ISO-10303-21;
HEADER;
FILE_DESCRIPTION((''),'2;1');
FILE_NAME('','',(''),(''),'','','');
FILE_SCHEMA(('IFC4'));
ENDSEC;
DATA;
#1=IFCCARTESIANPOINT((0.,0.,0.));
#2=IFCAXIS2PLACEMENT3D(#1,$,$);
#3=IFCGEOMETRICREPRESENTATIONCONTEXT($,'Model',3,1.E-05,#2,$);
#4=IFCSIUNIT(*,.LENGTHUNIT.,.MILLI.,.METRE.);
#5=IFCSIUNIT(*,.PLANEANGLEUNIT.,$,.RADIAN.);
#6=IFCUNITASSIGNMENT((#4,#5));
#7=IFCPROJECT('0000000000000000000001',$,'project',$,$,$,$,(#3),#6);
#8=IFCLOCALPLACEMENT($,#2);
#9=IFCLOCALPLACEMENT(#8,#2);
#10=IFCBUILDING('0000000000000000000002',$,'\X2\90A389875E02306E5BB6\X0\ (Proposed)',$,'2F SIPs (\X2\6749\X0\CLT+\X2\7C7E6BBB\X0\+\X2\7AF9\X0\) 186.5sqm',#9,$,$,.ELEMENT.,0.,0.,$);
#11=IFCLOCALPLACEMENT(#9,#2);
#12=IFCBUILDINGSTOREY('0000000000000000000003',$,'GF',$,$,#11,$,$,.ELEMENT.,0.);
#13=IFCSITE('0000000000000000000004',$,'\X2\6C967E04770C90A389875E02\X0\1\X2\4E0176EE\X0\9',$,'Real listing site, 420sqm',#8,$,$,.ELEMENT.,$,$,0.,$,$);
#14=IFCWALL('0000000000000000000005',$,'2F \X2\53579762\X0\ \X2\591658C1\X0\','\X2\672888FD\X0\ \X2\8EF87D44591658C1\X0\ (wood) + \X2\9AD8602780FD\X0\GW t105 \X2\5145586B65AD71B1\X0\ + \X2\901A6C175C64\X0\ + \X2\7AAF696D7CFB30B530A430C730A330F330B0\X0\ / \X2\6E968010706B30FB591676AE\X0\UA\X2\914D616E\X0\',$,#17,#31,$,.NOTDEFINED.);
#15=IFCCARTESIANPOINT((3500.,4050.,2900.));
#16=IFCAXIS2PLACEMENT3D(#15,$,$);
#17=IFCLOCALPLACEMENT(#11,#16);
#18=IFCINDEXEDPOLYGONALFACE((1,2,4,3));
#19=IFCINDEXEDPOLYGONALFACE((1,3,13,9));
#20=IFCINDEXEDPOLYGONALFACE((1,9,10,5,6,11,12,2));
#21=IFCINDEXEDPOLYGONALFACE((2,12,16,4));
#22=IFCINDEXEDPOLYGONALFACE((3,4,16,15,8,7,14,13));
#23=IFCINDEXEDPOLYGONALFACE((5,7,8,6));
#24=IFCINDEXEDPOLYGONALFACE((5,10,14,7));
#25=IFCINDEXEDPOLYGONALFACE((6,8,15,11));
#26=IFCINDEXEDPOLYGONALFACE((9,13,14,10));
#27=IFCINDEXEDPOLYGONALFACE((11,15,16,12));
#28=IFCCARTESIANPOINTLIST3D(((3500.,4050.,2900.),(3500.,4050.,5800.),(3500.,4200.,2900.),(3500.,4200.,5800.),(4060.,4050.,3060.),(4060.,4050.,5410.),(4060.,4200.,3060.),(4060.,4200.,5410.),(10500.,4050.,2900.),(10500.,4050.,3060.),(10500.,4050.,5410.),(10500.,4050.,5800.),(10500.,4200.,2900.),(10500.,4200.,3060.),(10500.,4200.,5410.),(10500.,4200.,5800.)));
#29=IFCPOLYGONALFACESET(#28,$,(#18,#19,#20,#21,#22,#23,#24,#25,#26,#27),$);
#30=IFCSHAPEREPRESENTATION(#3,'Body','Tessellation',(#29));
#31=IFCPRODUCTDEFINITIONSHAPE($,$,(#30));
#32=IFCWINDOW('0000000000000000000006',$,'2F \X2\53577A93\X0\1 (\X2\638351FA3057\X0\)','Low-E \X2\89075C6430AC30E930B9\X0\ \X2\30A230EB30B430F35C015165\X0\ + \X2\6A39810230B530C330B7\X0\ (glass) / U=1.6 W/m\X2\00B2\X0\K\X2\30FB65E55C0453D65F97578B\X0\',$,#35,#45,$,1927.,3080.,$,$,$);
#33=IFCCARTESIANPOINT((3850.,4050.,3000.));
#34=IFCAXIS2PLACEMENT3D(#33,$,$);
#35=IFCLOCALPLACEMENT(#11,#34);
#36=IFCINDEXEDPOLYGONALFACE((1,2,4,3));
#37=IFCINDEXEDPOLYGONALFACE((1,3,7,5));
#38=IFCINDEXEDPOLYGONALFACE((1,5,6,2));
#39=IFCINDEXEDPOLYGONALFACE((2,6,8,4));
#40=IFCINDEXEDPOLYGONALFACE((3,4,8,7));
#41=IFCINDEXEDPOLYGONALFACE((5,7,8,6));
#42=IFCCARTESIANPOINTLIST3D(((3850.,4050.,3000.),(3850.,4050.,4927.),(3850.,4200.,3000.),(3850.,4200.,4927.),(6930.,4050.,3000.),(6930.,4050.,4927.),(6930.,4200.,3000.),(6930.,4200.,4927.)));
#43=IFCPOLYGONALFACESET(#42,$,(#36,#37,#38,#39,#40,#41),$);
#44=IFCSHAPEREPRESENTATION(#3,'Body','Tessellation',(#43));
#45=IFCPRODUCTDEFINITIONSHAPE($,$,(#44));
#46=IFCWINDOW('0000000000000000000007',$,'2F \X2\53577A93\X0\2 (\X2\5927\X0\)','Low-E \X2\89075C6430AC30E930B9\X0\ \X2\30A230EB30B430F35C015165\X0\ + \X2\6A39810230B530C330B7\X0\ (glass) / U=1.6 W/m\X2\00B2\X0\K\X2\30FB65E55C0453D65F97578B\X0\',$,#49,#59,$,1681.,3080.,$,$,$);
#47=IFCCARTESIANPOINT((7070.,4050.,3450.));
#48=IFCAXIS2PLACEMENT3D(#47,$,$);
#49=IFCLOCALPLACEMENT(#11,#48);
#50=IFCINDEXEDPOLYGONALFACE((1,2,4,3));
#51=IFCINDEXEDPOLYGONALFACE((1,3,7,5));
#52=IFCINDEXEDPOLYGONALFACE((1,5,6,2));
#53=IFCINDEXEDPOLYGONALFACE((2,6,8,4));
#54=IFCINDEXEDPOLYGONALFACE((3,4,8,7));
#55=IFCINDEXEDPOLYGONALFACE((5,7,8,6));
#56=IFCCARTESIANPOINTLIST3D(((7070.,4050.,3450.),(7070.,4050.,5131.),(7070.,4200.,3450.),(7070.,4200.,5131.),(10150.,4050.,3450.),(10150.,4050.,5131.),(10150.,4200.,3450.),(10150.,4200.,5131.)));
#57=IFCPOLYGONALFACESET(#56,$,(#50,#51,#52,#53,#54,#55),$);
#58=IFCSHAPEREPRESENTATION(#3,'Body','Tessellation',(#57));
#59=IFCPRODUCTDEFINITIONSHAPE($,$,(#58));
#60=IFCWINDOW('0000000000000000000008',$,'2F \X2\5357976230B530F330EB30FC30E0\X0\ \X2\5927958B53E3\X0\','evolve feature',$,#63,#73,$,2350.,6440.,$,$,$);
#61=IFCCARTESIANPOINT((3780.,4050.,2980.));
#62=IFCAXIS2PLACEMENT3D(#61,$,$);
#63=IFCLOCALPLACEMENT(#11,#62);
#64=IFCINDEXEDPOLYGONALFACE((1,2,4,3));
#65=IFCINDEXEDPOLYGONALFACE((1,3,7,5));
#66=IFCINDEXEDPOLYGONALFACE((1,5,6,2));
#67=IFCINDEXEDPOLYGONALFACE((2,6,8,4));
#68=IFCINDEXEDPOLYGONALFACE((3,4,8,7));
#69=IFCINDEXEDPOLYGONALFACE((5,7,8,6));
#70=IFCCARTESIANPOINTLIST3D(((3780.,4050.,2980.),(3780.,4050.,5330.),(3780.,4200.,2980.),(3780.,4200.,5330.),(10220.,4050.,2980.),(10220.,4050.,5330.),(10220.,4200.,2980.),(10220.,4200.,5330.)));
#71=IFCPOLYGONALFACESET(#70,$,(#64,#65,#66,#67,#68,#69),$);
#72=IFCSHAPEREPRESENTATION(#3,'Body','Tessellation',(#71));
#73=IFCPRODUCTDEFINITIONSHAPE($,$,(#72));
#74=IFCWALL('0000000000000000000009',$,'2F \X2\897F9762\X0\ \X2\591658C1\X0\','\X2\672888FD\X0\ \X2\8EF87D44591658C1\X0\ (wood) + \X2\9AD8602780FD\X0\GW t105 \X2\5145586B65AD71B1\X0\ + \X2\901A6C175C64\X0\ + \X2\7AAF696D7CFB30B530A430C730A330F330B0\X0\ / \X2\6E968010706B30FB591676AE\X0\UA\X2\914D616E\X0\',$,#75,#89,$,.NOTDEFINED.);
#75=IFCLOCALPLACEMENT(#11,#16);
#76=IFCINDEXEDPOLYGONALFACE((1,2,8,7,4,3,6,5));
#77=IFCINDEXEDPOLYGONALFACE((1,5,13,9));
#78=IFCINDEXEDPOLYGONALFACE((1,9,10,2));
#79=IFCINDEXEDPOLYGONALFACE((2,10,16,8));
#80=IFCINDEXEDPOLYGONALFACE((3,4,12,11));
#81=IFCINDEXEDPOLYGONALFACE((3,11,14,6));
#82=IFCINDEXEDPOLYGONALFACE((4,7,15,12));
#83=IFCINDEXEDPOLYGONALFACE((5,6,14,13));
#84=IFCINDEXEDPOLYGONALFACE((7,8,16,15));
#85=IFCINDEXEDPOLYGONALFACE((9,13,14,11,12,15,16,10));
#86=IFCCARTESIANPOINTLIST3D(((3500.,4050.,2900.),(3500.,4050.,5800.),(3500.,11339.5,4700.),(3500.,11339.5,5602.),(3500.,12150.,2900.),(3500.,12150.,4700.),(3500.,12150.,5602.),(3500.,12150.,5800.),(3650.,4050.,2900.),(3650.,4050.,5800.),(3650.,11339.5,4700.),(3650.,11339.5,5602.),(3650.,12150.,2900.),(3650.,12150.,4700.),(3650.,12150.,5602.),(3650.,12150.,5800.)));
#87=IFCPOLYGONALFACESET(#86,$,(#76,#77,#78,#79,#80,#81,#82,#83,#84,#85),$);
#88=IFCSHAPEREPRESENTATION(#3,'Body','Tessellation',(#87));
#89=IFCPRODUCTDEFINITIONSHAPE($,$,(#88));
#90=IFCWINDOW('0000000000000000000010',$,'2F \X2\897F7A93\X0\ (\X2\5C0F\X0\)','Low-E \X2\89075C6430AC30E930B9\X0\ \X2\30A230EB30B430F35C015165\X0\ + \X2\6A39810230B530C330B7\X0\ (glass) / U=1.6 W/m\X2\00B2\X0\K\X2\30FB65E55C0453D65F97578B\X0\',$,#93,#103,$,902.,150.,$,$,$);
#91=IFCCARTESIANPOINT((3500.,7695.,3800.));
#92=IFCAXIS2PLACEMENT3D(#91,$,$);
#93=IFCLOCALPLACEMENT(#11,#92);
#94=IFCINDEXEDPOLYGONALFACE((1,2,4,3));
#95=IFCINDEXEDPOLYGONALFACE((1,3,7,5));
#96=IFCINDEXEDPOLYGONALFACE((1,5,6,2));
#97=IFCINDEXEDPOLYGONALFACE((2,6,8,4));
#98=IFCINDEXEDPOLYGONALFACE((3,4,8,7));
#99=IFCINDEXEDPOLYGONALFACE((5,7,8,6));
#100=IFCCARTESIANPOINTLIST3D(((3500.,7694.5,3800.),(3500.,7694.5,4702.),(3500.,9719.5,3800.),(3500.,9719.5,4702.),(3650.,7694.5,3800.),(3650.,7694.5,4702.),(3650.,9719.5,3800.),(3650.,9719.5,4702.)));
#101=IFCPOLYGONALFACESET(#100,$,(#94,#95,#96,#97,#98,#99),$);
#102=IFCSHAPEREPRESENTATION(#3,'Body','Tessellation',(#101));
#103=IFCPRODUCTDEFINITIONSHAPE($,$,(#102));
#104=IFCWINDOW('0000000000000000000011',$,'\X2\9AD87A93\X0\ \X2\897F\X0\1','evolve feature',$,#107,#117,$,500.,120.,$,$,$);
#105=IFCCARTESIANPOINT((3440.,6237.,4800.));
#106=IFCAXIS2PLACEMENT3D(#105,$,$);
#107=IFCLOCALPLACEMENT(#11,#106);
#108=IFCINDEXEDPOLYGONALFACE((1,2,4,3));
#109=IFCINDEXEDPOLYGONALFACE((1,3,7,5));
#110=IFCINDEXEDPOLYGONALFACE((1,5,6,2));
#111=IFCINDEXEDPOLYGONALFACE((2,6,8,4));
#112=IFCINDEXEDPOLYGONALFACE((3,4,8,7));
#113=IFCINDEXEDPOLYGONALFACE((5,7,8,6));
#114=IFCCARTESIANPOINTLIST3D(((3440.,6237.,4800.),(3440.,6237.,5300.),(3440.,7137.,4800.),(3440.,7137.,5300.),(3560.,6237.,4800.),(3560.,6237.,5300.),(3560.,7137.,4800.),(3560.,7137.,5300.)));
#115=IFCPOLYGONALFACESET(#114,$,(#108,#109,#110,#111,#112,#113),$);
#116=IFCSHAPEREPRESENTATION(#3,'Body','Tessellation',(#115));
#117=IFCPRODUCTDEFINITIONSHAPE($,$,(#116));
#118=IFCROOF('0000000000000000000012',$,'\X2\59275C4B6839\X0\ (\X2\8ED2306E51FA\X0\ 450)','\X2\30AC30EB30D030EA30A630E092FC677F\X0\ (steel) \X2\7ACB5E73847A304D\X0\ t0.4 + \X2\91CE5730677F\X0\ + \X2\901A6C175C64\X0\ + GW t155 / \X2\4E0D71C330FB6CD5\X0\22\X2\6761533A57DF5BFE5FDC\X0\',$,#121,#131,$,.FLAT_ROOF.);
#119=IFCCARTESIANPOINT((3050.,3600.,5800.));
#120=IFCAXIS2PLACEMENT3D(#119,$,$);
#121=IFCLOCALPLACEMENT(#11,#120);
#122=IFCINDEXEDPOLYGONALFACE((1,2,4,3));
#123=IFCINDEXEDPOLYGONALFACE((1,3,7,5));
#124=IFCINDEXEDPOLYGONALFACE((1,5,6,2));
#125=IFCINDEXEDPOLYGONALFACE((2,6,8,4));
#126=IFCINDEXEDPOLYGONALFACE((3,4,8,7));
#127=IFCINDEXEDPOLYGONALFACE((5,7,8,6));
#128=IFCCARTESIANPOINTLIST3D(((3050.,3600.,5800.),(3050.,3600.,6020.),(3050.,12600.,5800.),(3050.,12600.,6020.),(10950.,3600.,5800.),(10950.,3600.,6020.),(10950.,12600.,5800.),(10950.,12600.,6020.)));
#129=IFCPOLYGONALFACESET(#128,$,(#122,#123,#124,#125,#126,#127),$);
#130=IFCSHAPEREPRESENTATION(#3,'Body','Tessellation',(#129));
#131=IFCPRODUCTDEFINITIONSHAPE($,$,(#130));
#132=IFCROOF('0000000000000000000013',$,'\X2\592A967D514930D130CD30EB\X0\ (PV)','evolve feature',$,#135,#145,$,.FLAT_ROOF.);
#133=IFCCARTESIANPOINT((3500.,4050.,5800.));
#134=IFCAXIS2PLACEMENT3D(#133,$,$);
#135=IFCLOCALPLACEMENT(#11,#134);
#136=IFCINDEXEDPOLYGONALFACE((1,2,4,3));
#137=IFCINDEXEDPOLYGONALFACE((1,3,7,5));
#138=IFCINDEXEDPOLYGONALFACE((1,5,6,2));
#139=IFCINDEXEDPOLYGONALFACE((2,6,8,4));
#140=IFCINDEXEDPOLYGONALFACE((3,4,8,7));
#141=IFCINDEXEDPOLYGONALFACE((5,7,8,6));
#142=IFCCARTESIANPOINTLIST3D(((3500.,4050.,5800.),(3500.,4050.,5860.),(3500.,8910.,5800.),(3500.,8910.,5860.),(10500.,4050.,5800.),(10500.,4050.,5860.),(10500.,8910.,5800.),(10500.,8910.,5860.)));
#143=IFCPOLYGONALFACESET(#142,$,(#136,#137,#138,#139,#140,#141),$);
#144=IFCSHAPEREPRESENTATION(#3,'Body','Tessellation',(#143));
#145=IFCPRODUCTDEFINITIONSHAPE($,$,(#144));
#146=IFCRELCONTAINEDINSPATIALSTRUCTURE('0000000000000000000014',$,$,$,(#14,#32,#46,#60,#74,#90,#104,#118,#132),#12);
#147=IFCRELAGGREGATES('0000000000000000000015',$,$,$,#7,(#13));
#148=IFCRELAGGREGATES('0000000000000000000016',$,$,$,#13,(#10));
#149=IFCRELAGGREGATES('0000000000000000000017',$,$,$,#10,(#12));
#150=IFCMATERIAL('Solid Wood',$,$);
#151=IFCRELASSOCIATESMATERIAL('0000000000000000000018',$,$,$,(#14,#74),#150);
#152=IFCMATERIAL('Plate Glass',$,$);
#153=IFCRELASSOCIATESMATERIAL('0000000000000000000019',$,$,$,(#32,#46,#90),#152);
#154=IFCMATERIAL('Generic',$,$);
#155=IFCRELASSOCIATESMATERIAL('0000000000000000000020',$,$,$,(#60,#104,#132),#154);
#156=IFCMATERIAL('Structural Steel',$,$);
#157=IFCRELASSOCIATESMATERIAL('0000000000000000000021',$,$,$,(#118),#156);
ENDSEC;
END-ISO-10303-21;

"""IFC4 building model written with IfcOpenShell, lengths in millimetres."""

from ifc_helpers import new_model, si_unit, frame, frame_2d, origin, place, context, project, spatial, rectangle, extrude, material, element, fill, save


model = new_model("IFC4")

# Units and contexts
model_context = context("Model", 3, precision=1e-05, world=origin())
ifc_project = project(units=[si_unit("LENGTHUNIT", "METRE", prefix="MILLI"), si_unit("PLANEANGLEUNIT", "RADIAN")], contexts=[model_context])

# Site, building, storey
site_placement = place(None, origin())
site = spatial("IfcSite", under=ifc_project, at=site_placement, Name="沖縄県那覇市1丁目9", ObjectType="Real listing site, 420sqm", CompositionType="ELEMENT", RefElevation=0.0)
building_placement = place(site_placement, origin())
building = spatial("IfcBuilding", under=site, at=building_placement, Name="那覇市の家 (Proposed)", ObjectType="2F SIPs (杉CLT+籾殻+竹) 186.5sqm", CompositionType="ELEMENT", ElevationOfRefHeight=0.0, ElevationOfTerrain=0.0)
storey_placement = place(building_placement, origin())
storey = spatial("IfcBuildingStorey", under=building, at=storey_placement, Name="GF", CompositionType="ELEMENT", Elevation=0.0)

# Shared definitions
ifc_material_1 = material(Name="Solid Wood")
ifc_material_2 = material(Name="Generic")

# Shared definitions
ifc_material_3 = material(Name="Plate Glass")

# Walls, openings, windows
wall_1_placement = place(storey_placement, frame((3500.0, 4050.0, 2900.0)))
wall_1 = element("IfcWall", 1, at=wall_1_placement, inside=storey, material=ifc_material_1, Name="2F 南面 外壁", Description="木製 軸組外壁 (wood) + 高性能GW t105 充填断熱 + 通気層 + 窯業系サイディング / 準耐火・外皮UA配慮", PredefinedType="NOTDEFINED", context=model_context, shape_type="SweptSolid", body=[
    extrude(rectangle(XDim=7000.0, YDim=150.0, at=frame_2d((3500.0, 75.0))), frame((3500.0, 4050.0, 2900.0)), (0.0, 0.0, 1.0), 2900.0),
])
opening_1_placement = place(storey_placement, frame((3850.0, 4050.0, 3000.0)))
opening_1 = element("IfcOpeningElement", 2, at=opening_1_placement, cuts=wall_1, PredefinedType="NOTDEFINED", context=model_context, shape_type="SweptSolid", body=[
    extrude(rectangle(XDim=3080.0, YDim=150.0, at=frame_2d((1540.0, 75.0))), frame((3850.0, 4050.0, 3000.0)), (0.0, 0.0, 1.0), 1927.0),
])
opening_2_placement = place(storey_placement, frame((7070.0, 4050.0, 3450.0)))
opening_2 = element("IfcOpeningElement", 3, at=opening_2_placement, cuts=wall_1, PredefinedType="NOTDEFINED", context=model_context, shape_type="SweptSolid", body=[
    extrude(rectangle(XDim=3080.0, YDim=150.0, at=frame_2d((1540.0, 75.0))), frame((7070.0, 4050.0, 3450.0)), (0.0, 0.0, 1.0), 1681.0),
])
opening_3_placement = place(storey_placement, frame((3780.0, 4050.0, 2980.0)))
opening_3 = element("IfcOpeningElement", 4, at=opening_3_placement, cuts=wall_1, PredefinedType="NOTDEFINED", context=model_context, shape_type="SweptSolid", body=[
    extrude(rectangle(XDim=6440.0, YDim=150.0, at=frame_2d((3220.0, 75.0))), frame((3780.0, 4050.0, 2980.0)), (0.0, 0.0, 1.0), 2350.0),
])
window_1_placement = place(storey_placement, frame((3850.0, 4050.0, 3000.0)))
window_1 = element("IfcWindow", 5, at=window_1_placement, inside=storey, material=ifc_material_3, Name="2F 南窓1 (掃出し)", Description="Low-E 複層ガラス アルゴン封入 + 樹脂サッシ (glass) / U=1.6 W/m²K・日射取得型", OverallHeight=1927.0, OverallWidth=3080.0, context=model_context, shape_type="SweptSolid", body=[
    extrude(rectangle(XDim=3080.0, YDim=150.0, at=frame_2d((1540.0, 75.0))), frame((3850.0, 4050.0, 3000.0)), (0.0, 0.0, 1.0), 1927.0),
])
fill(opening_1, window_1)
window_2_placement = place(storey_placement, frame((7070.0, 4050.0, 3450.0)))
window_2 = element("IfcWindow", 6, at=window_2_placement, inside=storey, material=ifc_material_3, Name="2F 南窓2 (大)", Description="Low-E 複層ガラス アルゴン封入 + 樹脂サッシ (glass) / U=1.6 W/m²K・日射取得型", OverallHeight=1681.0, OverallWidth=3080.0, context=model_context, shape_type="SweptSolid", body=[
    extrude(rectangle(XDim=3080.0, YDim=150.0, at=frame_2d((1540.0, 75.0))), frame((7070.0, 4050.0, 3450.0)), (0.0, 0.0, 1.0), 1681.0),
])
fill(opening_2, window_2)
window_3_placement = place(storey_placement, frame((3780.0, 4050.0, 2980.0)))
window_3 = element("IfcWindow", 7, at=window_3_placement, inside=storey, material=ifc_material_2, Name="2F 南面サンルーム 大開口", Description="evolve feature", OverallHeight=2350.0, OverallWidth=6440.0, context=model_context, shape_type="SweptSolid", body=[
    extrude(rectangle(XDim=6440.0, YDim=150.0, at=frame_2d((3220.0, 75.0))), frame((3780.0, 4050.0, 2980.0)), (0.0, 0.0, 1.0), 2350.0),
])
fill(opening_3, window_3)
wall_2_placement = place(storey_placement, frame((3500.0, 4050.0, 2900.0)))
wall_2 = element("IfcWall", 8, at=wall_2_placement, inside=storey, material=ifc_material_1, Name="2F 西面 外壁", Description="木製 軸組外壁 (wood) + 高性能GW t105 充填断熱 + 通気層 + 窯業系サイディング / 準耐火・外皮UA配慮", PredefinedType="NOTDEFINED", context=model_context, shape_type="SweptSolid", body=[
    extrude(rectangle(XDim=150.0, YDim=8100.0, at=frame_2d((75.0, 4050.0))), frame((3500.0, 4050.0, 2900.0)), (0.0, 0.0, 1.0), 2900.0),
])
opening_4_placement = place(storey_placement, frame((3500.0, 7695.0, 3800.0)))
opening_4 = element("IfcOpeningElement", 9, at=opening_4_placement, cuts=wall_2, PredefinedType="NOTDEFINED", context=model_context, shape_type="SweptSolid", body=[
    extrude(rectangle(XDim=150.0, YDim=2025.0, at=frame_2d((75.0, 1012.0))), frame((3500.0, 7695.0, 3800.0)), (0.0, 0.0, 1.0), 902.0),
])
opening_5_placement = place(storey_placement, frame((3440.0, 6237.0, 4800.0)))
opening_5 = element("IfcOpeningElement", 10, at=opening_5_placement, cuts=wall_2, PredefinedType="NOTDEFINED", context=model_context, shape_type="SweptSolid", body=[
    extrude(rectangle(XDim=120.0, YDim=900.0, at=frame_2d((60.0, 450.0))), frame((3440.0, 6237.0, 4800.0)), (0.0, 0.0, 1.0), 500.0),
])
window_4_placement = place(storey_placement, frame((3500.0, 7695.0, 3800.0)))
window_4 = element("IfcWindow", 11, at=window_4_placement, inside=storey, material=ifc_material_3, Name="2F 西窓 (小)", Description="Low-E 複層ガラス アルゴン封入 + 樹脂サッシ (glass) / U=1.6 W/m²K・日射取得型", OverallHeight=902.0, OverallWidth=150.0, context=model_context, shape_type="SweptSolid", body=[
    extrude(rectangle(XDim=150.0, YDim=2025.0, at=frame_2d((75.0, 1012.0))), frame((3500.0, 7695.0, 3800.0)), (0.0, 0.0, 1.0), 902.0),
])
fill(opening_4, window_4)
window_5_placement = place(storey_placement, frame((3440.0, 6237.0, 4800.0)))
window_5 = element("IfcWindow", 12, at=window_5_placement, inside=storey, material=ifc_material_2, Name="高窓 西1", Description="evolve feature", OverallHeight=500.0, OverallWidth=120.0, context=model_context, shape_type="SweptSolid", body=[
    extrude(rectangle(XDim=120.0, YDim=900.0, at=frame_2d((60.0, 450.0))), frame((3440.0, 6237.0, 4800.0)), (0.0, 0.0, 1.0), 500.0),
])
fill(opening_5, window_5)

# Roofs
ifc_material_4 = material(Name="Structural Steel")
roof_1_placement = place(storey_placement, frame((3050.0, 3600.0, 5800.0)))
element("IfcRoof", 13, at=roof_1_placement, inside=storey, material=ifc_material_4, Name="大屋根 (軒の出 450)", Description="ガルバリウム鋼板 (steel) 立平葺き t0.4 + 野地板 + 通気層 + GW t155 / 不燃・法22条区域対応", PredefinedType="FLAT_ROOF", context=model_context, shape_type="SweptSolid", body=[
    extrude(rectangle(XDim=7900.0, YDim=9000.0, at=frame_2d((3950.0, 4500.0))), frame((3050.0, 3600.0, 5800.0)), (0.0, 0.0, 1.0), 220.0),
])
roof_2_placement = place(storey_placement, frame((3500.0, 4050.0, 5800.0)))
element("IfcRoof", 14, at=roof_2_placement, inside=storey, material=ifc_material_2, Name="太陽光パネル (PV)", Description="evolve feature", PredefinedType="FLAT_ROOF", context=model_context, shape_type="SweptSolid", body=[
    extrude(rectangle(XDim=7000.0, YDim=4860.0, at=frame_2d((3500.0, 2430.0))), frame((3500.0, 4050.0, 5800.0)), (0.0, 0.0, 1.0), 60.0),
])

save(model, "model.ifc")
